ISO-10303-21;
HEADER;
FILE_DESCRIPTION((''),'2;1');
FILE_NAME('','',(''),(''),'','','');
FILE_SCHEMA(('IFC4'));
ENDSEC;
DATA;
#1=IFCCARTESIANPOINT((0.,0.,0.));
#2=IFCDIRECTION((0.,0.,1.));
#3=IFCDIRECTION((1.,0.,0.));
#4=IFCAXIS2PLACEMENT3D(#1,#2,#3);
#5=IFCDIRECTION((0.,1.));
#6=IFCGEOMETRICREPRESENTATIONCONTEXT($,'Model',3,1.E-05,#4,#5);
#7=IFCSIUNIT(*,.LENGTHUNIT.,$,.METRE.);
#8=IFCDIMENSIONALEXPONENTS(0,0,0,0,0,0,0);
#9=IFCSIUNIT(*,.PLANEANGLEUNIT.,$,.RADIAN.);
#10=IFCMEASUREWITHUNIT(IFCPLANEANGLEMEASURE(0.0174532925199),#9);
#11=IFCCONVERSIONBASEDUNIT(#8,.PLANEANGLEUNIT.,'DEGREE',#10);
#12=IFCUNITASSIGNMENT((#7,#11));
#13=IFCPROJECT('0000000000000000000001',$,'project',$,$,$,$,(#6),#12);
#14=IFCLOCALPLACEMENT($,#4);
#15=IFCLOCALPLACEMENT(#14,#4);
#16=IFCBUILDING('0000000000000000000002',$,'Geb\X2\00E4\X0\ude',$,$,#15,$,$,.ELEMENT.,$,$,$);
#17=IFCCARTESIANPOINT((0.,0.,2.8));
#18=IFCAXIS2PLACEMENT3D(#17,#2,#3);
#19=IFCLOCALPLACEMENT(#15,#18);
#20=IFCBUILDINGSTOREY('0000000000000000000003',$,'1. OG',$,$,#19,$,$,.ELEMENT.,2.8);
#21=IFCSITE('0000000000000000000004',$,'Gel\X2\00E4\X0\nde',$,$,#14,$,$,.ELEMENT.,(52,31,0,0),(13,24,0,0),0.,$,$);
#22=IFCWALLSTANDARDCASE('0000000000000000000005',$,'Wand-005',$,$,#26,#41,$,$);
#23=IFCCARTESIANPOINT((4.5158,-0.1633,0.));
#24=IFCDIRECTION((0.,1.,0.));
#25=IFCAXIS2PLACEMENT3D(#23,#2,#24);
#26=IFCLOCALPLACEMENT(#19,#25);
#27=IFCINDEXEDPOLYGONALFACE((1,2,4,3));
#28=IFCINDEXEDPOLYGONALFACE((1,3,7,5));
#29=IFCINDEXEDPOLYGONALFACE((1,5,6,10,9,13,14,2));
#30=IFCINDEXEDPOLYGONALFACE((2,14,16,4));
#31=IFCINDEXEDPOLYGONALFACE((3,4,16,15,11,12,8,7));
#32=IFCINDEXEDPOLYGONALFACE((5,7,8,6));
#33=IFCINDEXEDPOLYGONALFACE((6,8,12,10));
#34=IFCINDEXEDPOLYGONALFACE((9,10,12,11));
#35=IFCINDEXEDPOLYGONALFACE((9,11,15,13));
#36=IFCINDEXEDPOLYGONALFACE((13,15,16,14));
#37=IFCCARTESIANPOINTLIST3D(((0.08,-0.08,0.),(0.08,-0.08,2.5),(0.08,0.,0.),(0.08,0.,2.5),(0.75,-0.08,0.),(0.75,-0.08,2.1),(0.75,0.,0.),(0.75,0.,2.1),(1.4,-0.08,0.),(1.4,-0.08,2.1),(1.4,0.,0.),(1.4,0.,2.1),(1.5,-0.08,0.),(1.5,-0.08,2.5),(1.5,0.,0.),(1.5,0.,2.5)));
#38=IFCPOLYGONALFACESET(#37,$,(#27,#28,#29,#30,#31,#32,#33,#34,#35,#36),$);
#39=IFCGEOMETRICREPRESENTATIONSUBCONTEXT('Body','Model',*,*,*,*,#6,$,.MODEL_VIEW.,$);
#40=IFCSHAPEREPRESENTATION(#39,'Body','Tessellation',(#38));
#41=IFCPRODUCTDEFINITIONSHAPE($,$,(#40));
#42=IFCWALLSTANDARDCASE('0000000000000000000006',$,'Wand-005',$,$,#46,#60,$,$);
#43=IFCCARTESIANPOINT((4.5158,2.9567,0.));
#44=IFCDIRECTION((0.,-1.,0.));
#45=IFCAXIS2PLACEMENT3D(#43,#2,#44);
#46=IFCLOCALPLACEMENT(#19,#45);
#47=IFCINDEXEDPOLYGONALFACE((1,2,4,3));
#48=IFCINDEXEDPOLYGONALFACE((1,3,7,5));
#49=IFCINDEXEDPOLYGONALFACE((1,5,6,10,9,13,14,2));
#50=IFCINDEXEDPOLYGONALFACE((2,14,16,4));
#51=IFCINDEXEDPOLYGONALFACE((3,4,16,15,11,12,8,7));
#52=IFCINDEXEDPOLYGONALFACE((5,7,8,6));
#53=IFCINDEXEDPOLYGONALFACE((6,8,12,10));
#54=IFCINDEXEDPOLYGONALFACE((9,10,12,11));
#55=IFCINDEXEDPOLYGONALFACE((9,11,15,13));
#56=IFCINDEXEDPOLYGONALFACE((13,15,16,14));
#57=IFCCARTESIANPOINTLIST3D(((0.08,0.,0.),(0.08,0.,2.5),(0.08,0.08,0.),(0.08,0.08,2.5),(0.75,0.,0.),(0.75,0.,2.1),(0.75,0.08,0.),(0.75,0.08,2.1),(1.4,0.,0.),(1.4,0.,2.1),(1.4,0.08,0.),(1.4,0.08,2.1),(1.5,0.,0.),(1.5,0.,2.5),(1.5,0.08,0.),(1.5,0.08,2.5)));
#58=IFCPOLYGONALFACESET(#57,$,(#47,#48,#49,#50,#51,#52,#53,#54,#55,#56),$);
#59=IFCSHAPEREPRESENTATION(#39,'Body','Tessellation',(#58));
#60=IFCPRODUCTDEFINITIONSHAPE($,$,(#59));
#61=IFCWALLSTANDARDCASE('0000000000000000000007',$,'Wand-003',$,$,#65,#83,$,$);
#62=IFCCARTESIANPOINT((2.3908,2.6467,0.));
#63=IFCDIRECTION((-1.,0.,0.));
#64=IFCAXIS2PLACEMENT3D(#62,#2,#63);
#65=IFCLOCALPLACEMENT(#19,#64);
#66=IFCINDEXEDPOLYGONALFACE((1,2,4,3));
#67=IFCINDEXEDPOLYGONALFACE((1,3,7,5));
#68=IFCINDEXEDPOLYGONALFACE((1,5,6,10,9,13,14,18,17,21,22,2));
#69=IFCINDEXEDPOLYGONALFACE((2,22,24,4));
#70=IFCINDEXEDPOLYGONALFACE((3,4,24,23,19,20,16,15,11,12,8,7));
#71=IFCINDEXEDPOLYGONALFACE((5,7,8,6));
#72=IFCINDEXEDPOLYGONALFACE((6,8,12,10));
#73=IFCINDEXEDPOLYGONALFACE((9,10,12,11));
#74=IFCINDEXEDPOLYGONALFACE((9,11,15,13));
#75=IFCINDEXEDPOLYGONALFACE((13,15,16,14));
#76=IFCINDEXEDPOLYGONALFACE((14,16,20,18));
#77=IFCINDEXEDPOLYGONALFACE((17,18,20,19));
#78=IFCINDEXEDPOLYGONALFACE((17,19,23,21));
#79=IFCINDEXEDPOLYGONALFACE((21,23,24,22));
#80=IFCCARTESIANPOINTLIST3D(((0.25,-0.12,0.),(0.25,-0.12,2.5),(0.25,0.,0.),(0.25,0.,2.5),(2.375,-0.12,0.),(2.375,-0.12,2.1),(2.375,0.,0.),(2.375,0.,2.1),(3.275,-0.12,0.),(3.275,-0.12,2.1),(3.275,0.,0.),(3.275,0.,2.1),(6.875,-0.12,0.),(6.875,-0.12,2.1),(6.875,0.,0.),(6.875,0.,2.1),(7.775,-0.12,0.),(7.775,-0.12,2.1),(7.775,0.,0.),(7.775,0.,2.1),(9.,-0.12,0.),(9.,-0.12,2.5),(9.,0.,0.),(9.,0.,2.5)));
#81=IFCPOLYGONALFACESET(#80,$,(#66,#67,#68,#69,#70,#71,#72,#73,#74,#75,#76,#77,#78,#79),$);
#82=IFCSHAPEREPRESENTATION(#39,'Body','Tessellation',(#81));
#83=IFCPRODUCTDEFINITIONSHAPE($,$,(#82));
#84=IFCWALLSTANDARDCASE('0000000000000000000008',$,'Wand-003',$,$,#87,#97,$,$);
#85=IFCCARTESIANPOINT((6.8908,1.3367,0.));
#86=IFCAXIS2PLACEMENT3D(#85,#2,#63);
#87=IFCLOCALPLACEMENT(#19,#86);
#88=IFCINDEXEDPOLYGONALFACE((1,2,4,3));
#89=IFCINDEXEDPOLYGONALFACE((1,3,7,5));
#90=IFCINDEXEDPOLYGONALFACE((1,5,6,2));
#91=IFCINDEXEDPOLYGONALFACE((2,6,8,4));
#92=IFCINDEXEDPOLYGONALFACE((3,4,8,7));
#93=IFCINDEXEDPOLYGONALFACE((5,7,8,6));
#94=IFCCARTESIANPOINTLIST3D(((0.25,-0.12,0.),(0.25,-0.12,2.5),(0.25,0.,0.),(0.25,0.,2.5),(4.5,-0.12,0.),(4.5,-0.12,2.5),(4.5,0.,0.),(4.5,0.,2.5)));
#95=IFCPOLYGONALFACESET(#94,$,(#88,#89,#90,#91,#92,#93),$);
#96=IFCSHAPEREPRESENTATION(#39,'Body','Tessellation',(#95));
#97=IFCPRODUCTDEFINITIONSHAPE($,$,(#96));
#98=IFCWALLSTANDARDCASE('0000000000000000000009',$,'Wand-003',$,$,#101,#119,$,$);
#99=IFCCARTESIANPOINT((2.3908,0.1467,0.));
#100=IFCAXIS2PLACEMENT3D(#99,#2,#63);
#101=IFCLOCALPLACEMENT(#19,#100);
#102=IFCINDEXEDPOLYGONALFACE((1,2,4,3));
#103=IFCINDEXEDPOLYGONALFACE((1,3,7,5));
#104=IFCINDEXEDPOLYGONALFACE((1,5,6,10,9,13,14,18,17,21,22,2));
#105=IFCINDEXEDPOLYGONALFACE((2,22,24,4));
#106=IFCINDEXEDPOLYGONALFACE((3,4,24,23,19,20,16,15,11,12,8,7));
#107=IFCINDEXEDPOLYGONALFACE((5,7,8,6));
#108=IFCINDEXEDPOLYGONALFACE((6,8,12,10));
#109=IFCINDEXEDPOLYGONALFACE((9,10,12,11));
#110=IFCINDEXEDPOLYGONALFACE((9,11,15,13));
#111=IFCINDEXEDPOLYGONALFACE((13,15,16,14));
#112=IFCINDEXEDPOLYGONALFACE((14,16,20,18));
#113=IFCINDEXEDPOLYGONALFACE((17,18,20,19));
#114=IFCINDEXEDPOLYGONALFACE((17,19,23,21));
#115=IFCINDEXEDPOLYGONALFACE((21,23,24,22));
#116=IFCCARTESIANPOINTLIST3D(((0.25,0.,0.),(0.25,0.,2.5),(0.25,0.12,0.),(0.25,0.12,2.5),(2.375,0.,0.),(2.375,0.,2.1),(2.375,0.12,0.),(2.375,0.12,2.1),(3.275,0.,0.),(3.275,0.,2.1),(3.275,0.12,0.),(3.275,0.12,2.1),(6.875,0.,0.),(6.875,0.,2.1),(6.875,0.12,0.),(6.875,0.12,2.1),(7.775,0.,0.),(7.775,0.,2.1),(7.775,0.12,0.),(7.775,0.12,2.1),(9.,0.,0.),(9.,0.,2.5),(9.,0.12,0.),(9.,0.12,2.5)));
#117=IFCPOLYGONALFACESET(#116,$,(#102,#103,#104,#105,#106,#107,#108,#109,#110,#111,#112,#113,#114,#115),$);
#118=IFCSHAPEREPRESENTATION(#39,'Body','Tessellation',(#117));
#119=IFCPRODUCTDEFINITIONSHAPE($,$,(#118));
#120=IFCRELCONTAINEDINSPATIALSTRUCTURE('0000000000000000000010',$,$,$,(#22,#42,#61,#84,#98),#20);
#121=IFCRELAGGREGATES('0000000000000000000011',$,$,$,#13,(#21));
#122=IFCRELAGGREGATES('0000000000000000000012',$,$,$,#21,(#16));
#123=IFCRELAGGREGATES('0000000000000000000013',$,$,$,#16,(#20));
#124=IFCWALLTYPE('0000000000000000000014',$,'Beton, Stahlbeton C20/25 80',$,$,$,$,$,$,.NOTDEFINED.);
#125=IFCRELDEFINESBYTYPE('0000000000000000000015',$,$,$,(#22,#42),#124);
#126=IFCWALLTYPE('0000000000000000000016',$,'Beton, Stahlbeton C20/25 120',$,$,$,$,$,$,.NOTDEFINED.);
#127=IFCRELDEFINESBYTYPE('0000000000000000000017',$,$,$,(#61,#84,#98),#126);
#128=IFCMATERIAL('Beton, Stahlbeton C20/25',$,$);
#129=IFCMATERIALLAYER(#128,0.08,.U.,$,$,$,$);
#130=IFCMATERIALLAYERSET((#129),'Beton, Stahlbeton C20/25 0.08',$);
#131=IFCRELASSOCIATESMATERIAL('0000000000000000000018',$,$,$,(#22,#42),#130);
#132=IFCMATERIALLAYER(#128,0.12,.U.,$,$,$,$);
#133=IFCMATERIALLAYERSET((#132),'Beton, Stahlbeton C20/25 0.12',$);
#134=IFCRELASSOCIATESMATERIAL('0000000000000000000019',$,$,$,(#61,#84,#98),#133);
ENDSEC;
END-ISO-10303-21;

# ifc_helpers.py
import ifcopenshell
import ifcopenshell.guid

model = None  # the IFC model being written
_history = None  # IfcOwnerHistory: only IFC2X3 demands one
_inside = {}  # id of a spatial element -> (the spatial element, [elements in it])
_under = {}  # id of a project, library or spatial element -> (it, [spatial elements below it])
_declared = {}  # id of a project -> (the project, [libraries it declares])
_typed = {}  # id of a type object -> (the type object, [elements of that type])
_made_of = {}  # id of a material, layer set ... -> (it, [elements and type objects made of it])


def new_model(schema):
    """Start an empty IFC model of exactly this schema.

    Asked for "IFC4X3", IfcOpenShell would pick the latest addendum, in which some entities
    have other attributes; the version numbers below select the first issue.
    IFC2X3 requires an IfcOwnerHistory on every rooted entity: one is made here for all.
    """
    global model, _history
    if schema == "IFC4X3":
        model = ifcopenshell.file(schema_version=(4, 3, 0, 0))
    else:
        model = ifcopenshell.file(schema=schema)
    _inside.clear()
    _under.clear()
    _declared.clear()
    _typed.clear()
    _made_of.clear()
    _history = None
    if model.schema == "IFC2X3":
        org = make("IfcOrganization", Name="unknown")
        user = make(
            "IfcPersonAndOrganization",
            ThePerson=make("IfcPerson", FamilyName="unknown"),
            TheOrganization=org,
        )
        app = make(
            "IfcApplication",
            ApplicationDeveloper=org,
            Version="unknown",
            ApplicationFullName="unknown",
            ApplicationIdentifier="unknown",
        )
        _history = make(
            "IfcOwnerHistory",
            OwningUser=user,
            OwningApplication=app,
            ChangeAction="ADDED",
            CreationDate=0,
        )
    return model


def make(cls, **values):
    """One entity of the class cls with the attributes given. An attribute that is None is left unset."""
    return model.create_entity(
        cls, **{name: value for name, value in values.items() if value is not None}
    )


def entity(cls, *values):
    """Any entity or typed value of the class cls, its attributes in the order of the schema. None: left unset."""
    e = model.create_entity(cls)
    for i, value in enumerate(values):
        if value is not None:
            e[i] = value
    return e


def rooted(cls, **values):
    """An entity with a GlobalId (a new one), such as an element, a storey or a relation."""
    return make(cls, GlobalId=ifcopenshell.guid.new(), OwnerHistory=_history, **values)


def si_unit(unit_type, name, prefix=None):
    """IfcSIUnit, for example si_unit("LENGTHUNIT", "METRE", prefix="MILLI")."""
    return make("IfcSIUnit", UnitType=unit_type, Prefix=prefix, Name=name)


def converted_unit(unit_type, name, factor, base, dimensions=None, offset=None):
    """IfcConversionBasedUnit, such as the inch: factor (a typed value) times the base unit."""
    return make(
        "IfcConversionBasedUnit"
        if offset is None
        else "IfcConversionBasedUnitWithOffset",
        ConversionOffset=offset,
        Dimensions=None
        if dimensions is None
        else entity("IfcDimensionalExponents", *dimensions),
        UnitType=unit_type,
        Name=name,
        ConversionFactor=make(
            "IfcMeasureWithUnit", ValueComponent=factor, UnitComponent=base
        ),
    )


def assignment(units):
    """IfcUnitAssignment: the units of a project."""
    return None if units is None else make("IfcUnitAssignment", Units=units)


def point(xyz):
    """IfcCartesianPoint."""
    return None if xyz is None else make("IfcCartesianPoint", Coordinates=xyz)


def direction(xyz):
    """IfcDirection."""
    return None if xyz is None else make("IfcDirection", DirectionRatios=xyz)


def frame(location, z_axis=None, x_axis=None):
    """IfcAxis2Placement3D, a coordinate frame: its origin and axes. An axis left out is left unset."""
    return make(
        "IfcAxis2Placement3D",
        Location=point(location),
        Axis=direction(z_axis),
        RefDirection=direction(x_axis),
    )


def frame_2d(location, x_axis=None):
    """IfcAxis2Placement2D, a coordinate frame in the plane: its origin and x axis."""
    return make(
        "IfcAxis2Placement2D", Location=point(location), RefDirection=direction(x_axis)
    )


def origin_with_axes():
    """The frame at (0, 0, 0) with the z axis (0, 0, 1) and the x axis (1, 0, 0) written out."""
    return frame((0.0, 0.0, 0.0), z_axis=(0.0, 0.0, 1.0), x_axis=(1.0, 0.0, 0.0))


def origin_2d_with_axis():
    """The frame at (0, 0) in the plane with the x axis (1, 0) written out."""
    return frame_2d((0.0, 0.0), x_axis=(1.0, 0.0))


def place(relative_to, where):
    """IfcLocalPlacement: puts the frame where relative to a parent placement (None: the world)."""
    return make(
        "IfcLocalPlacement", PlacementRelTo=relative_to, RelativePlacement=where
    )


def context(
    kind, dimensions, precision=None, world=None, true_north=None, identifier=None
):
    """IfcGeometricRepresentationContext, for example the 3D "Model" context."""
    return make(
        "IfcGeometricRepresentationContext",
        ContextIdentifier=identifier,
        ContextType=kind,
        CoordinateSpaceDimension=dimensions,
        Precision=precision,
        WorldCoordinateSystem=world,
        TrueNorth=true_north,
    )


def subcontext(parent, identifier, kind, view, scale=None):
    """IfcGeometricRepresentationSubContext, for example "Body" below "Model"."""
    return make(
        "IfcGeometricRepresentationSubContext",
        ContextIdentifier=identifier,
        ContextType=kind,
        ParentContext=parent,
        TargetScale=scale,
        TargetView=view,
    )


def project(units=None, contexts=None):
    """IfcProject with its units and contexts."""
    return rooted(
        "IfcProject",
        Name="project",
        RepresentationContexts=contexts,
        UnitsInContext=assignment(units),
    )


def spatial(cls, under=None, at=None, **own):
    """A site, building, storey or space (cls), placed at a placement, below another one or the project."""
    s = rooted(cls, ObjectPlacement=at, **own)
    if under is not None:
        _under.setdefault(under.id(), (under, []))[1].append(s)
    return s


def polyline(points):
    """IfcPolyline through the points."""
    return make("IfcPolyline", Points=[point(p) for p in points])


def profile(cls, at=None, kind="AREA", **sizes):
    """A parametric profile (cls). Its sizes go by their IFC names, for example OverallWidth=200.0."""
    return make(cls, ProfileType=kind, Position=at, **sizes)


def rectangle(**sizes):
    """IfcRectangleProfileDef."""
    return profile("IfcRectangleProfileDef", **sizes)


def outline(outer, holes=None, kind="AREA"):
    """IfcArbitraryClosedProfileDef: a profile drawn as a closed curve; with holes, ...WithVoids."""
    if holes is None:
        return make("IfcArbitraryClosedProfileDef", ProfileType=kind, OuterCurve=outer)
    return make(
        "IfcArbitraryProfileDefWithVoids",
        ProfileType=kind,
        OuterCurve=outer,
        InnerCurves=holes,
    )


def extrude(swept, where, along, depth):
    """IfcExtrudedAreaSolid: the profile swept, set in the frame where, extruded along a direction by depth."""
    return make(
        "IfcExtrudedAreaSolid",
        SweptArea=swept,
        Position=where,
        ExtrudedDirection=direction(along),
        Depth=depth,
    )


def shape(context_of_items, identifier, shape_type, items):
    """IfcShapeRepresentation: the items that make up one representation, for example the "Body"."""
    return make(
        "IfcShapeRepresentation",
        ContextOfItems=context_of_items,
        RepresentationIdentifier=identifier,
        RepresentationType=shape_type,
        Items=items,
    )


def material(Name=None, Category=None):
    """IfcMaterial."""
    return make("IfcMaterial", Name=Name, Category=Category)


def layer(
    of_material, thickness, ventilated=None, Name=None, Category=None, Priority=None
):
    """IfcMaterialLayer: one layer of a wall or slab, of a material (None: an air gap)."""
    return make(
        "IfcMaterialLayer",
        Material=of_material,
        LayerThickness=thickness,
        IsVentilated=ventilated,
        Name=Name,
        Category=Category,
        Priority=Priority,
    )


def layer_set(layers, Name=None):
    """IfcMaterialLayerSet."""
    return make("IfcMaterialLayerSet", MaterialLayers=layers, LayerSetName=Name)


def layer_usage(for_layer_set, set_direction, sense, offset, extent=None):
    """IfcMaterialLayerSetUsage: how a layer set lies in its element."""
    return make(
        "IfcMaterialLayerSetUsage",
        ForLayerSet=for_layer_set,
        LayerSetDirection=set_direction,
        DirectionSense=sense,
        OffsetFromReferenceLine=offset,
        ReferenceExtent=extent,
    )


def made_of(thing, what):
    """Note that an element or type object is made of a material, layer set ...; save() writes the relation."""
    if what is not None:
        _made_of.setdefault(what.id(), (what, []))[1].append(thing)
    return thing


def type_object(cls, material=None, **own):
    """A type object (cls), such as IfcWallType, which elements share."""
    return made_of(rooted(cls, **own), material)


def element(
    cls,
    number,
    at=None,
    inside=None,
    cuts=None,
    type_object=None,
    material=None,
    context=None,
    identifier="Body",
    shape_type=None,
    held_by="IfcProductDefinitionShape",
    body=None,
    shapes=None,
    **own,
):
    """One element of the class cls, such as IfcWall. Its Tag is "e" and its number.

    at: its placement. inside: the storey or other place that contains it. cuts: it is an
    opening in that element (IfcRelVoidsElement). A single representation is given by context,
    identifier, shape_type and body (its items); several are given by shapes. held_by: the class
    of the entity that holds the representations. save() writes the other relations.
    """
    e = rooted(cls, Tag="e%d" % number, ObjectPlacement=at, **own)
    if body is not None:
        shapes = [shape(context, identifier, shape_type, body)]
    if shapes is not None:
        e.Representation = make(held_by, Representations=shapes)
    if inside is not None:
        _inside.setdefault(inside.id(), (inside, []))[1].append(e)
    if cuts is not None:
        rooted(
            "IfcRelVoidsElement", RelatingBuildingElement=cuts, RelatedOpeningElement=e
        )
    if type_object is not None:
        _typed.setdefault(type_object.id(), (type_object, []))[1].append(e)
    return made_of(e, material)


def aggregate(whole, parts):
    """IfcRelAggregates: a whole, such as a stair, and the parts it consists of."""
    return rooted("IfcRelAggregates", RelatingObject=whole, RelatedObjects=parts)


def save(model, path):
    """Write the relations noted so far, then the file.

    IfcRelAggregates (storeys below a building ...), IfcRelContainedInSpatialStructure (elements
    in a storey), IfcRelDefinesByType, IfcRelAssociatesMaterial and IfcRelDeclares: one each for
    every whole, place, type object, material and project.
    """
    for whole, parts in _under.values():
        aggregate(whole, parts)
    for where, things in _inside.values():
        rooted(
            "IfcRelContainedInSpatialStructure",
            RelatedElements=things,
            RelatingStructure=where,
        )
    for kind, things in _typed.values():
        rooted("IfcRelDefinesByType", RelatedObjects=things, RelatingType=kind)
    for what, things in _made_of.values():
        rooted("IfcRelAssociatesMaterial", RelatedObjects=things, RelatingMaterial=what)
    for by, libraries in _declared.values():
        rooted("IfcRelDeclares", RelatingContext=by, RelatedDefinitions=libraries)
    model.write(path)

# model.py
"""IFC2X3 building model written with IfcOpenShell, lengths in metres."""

from ifc_helpers import new_model, entity, si_unit, converted_unit, direction, frame, origin_with_axes, origin_2d_with_axis, place, context, subcontext, project, spatial, polyline, rectangle, outline, extrude, material, layer, layer_set, layer_usage, type_object, element, save


model = new_model("IFC2X3")

# Units and contexts
model_context = context("Model", 3, precision=1e-05, world=origin_with_axes(), true_north=direction((0.0, 1.0)))
body_context = subcontext(model_context, "Body", "Model", "MODEL_VIEW")
ifc_project = project(units=[si_unit("LENGTHUNIT", "METRE"), converted_unit("PLANEANGLEUNIT", "DEGREE", entity("IfcPlaneAngleMeasure", 0.0174532925199), si_unit("PLANEANGLEUNIT", "RADIAN"), dimensions=[0, 0, 0, 0, 0, 0, 0])], contexts=[model_context])

# Site, building, storey
site_placement = place(None, origin_with_axes())
site = spatial("IfcSite", under=ifc_project, at=site_placement, Name="Gelände", CompositionType="ELEMENT", RefLatitude=(52, 31, 0, 0), RefLongitude=(13, 24, 0, 0), RefElevation=0.0)
building_placement = place(site_placement, origin_with_axes())
building = spatial("IfcBuilding", under=site, at=building_placement, Name="Gebäude", CompositionType="ELEMENT")
storey_placement = place(building_placement, frame((0.0, 0.0, 2.8), z_axis=(0.0, 0.0, 1.0), x_axis=(1.0, 0.0, 0.0)))
storey = spatial("IfcBuildingStorey", under=building, at=storey_placement, Name="1. OG", CompositionType="ELEMENT", Elevation=2.8)

# Shared definitions
ifc_material_1 = material(Name="Beton, Stahlbeton C20/25")
ifc_layer_1 = layer(ifc_material_1, 0.08, ventilated="UNKNOWN")
ifc_layer_set_1 = layer_set([ifc_layer_1], Name="Beton, Stahlbeton C20/25 0.08")
wall_type_1 = type_object("IfcWallType", Name="Beton, Stahlbeton C20/25 80", PredefinedType="NOTDEFINED")

# Wall, opening
ifc_layer_usage_1 = layer_usage(ifc_layer_set_1, "AXIS2", "NEGATIVE", 0.0)
wall_1_placement = place(storey_placement, frame((4.5158, -0.1633, 0.0), z_axis=(0.0, 0.0, 1.0), x_axis=(0.0, 1.0, 0.0)))
wall_1 = element("IfcWallStandardCase", 1, at=wall_1_placement, inside=storey, type_object=wall_type_1, material=ifc_layer_usage_1, Name="Wand-005", context=body_context, shape_type="SweptSolid", body=[
    extrude(outline(polyline([(0.08, -0.08), (1.5, -0.08), (1.5, 0.0), (0.08, 0.0), (0.08, -0.08)])), origin_with_axes(), (0.0, 0.0, 1.0), 2.5),
])
opening_1_placement = place(wall_1_placement, frame((1.075, 0.0, 0.0), z_axis=(0.0, 0.0, 1.0), x_axis=(1.0, 0.0, 0.0)))
element("IfcOpeningElement", 2, at=opening_1_placement, cuts=wall_1, context=body_context, shape_type="SweptSolid", body=[
    extrude(rectangle(XDim=0.65, YDim=2.1, at=origin_2d_with_axis()), frame((0.0, 0.08, 1.05), z_axis=(0.0, 1.0, 0.0), x_axis=(-1.0, 0.0, 0.0)), (0.0, 0.0, -1.0), 0.24),
])

# Wall, opening
ifc_layer_usage_2 = layer_usage(ifc_layer_set_1, "AXIS2", "POSITIVE", 0.0)
wall_2_placement = place(storey_placement, frame((4.5158, 2.9567, 0.0), z_axis=(0.0, 0.0, 1.0), x_axis=(0.0, -1.0, 0.0)))
wall_2 = element("IfcWallStandardCase", 3, at=wall_2_placement, inside=storey, type_object=wall_type_1, material=ifc_layer_usage_2, Name="Wand-005", context=body_context, shape_type="SweptSolid", body=[
    extrude(outline(polyline([(0.08, 0.0), (1.5, 0.0), (1.5, 0.08), (0.08, 0.08), (0.08, 0.0)])), origin_with_axes(), (0.0, 0.0, 1.0), 2.5),
])
opening_2_placement = place(wall_2_placement, frame((1.075, 0.0, 0.0), z_axis=(0.0, 0.0, 1.0), x_axis=(1.0, 0.0, 0.0)))
element("IfcOpeningElement", 4, at=opening_2_placement, cuts=wall_2, context=body_context, shape_type="SweptSolid", body=[
    extrude(rectangle(XDim=0.65, YDim=2.1, at=origin_2d_with_axis()), frame((0.0, -0.08, 1.05), z_axis=(0.0, 1.0, 0.0), x_axis=(-1.0, 0.0, 0.0)), (0.0, 0.0, 1.0), 0.24),
])

# Wall, openings
ifc_layer_2 = layer(ifc_material_1, 0.12, ventilated="UNKNOWN")
ifc_layer_set_2 = layer_set([ifc_layer_2], Name="Beton, Stahlbeton C20/25 0.12")
ifc_layer_usage_3 = layer_usage(ifc_layer_set_2, "AXIS2", "NEGATIVE", 0.0)
wall_type_2 = type_object("IfcWallType", Name="Beton, Stahlbeton C20/25 120", PredefinedType="NOTDEFINED")
wall_3_placement = place(storey_placement, frame((2.3908, 2.6467, 0.0), z_axis=(0.0, 0.0, 1.0), x_axis=(-1.0, 0.0, 0.0)))
wall_3 = element("IfcWallStandardCase", 5, at=wall_3_placement, inside=storey, type_object=wall_type_2, material=ifc_layer_usage_3, Name="Wand-003", context=body_context, shape_type="SweptSolid", body=[
    extrude(outline(polyline([(0.25, -0.12), (9.0, -0.12), (9.0, 0.0), (0.25, 0.0), (0.25, -0.12)])), origin_with_axes(), (0.0, 0.0, 1.0), 2.5),
])
opening_3_placement = place(wall_3_placement, frame((7.325, 0.0, 0.0), z_axis=(0.0, 0.0, 1.0), x_axis=(1.0, 0.0, 0.0)))
element("IfcOpeningElement", 6, at=opening_3_placement, cuts=wall_3, context=body_context, shape_type="SweptSolid", body=[
    extrude(rectangle(XDim=0.9, YDim=2.1, at=origin_2d_with_axis()), frame((0.0, -0.24, 1.05), z_axis=(0.0, 1.0, 0.0), x_axis=(-1.0, 0.0, 0.0)), (0.0, 0.0, 1.0), 0.36),
])
opening_4_placement = place(wall_3_placement, frame((2.825, 0.0, 0.0), z_axis=(0.0, 0.0, 1.0), x_axis=(1.0, 0.0, 0.0)))
element("IfcOpeningElement", 7, at=opening_4_placement, cuts=wall_3, context=body_context, shape_type="SweptSolid", body=[
    extrude(rectangle(XDim=0.9, YDim=2.1, at=origin_2d_with_axis()), frame((0.0, -0.24, 1.05), z_axis=(0.0, 1.0, 0.0), x_axis=(-1.0, 0.0, 0.0)), (0.0, 0.0, 1.0), 0.36),
])

# Wall
ifc_layer_usage_4 = layer_usage(ifc_layer_set_2, "AXIS2", "NEGATIVE", 0.0)
wall_4_placement = place(storey_placement, frame((6.8908, 1.3367, 0.0), z_axis=(0.0, 0.0, 1.0), x_axis=(-1.0, 0.0, 0.0)))
element("IfcWallStandardCase", 8, at=wall_4_placement, inside=storey, type_object=wall_type_2, material=ifc_layer_usage_4, Name="Wand-003", context=body_context, shape_type="SweptSolid", body=[
    extrude(outline(polyline([(0.25, -0.12), (4.5, -0.12), (4.5, 0.0), (0.25, 0.0), (0.25, -0.12)])), origin_with_axes(), (0.0, 0.0, 1.0), 2.5),
])

# Wall, openings
ifc_layer_usage_5 = layer_usage(ifc_layer_set_2, "AXIS2", "POSITIVE", 0.0)
wall_5_placement = place(storey_placement, frame((2.3908, 0.1467, 0.0), z_axis=(0.0, 0.0, 1.0), x_axis=(-1.0, 0.0, 0.0)))
wall_5 = element("IfcWallStandardCase", 9, at=wall_5_placement, inside=storey, type_object=wall_type_2, material=ifc_layer_usage_5, Name="Wand-003", context=body_context, shape_type="SweptSolid", body=[
    extrude(outline(polyline([(0.25, 0.0), (9.0, 0.0), (9.0, 0.12), (0.25, 0.12), (0.25, 0.0)])), origin_with_axes(), (0.0, 0.0, 1.0), 2.5),
])
opening_5_placement = place(wall_5_placement, frame((7.325, 0.0, 0.0), z_axis=(0.0, 0.0, 1.0), x_axis=(1.0, 0.0, 0.0)))
element("IfcOpeningElement", 10, at=opening_5_placement, cuts=wall_5, context=body_context, shape_type="SweptSolid", body=[
    extrude(rectangle(XDim=0.9, YDim=2.1, at=origin_2d_with_axis()), frame((0.0, 0.24, 1.05), z_axis=(0.0, 1.0, 0.0), x_axis=(-1.0, 0.0, 0.0)), (0.0, 0.0, -1.0), 0.36),
])
opening_6_placement = place(wall_5_placement, frame((2.825, 0.0, 0.0), z_axis=(0.0, 0.0, 1.0), x_axis=(1.0, 0.0, 0.0)))
element("IfcOpeningElement", 11, at=opening_6_placement, cuts=wall_5, context=body_context, shape_type="SweptSolid", body=[
    extrude(rectangle(XDim=0.9, YDim=2.1, at=origin_2d_with_axis()), frame((0.0, 0.24, 1.05), z_axis=(0.0, 1.0, 0.0), x_axis=(-1.0, 0.0, 0.0)), (0.0, 0.0, -1.0), 0.36),
])

save(model, "model.ifc")
